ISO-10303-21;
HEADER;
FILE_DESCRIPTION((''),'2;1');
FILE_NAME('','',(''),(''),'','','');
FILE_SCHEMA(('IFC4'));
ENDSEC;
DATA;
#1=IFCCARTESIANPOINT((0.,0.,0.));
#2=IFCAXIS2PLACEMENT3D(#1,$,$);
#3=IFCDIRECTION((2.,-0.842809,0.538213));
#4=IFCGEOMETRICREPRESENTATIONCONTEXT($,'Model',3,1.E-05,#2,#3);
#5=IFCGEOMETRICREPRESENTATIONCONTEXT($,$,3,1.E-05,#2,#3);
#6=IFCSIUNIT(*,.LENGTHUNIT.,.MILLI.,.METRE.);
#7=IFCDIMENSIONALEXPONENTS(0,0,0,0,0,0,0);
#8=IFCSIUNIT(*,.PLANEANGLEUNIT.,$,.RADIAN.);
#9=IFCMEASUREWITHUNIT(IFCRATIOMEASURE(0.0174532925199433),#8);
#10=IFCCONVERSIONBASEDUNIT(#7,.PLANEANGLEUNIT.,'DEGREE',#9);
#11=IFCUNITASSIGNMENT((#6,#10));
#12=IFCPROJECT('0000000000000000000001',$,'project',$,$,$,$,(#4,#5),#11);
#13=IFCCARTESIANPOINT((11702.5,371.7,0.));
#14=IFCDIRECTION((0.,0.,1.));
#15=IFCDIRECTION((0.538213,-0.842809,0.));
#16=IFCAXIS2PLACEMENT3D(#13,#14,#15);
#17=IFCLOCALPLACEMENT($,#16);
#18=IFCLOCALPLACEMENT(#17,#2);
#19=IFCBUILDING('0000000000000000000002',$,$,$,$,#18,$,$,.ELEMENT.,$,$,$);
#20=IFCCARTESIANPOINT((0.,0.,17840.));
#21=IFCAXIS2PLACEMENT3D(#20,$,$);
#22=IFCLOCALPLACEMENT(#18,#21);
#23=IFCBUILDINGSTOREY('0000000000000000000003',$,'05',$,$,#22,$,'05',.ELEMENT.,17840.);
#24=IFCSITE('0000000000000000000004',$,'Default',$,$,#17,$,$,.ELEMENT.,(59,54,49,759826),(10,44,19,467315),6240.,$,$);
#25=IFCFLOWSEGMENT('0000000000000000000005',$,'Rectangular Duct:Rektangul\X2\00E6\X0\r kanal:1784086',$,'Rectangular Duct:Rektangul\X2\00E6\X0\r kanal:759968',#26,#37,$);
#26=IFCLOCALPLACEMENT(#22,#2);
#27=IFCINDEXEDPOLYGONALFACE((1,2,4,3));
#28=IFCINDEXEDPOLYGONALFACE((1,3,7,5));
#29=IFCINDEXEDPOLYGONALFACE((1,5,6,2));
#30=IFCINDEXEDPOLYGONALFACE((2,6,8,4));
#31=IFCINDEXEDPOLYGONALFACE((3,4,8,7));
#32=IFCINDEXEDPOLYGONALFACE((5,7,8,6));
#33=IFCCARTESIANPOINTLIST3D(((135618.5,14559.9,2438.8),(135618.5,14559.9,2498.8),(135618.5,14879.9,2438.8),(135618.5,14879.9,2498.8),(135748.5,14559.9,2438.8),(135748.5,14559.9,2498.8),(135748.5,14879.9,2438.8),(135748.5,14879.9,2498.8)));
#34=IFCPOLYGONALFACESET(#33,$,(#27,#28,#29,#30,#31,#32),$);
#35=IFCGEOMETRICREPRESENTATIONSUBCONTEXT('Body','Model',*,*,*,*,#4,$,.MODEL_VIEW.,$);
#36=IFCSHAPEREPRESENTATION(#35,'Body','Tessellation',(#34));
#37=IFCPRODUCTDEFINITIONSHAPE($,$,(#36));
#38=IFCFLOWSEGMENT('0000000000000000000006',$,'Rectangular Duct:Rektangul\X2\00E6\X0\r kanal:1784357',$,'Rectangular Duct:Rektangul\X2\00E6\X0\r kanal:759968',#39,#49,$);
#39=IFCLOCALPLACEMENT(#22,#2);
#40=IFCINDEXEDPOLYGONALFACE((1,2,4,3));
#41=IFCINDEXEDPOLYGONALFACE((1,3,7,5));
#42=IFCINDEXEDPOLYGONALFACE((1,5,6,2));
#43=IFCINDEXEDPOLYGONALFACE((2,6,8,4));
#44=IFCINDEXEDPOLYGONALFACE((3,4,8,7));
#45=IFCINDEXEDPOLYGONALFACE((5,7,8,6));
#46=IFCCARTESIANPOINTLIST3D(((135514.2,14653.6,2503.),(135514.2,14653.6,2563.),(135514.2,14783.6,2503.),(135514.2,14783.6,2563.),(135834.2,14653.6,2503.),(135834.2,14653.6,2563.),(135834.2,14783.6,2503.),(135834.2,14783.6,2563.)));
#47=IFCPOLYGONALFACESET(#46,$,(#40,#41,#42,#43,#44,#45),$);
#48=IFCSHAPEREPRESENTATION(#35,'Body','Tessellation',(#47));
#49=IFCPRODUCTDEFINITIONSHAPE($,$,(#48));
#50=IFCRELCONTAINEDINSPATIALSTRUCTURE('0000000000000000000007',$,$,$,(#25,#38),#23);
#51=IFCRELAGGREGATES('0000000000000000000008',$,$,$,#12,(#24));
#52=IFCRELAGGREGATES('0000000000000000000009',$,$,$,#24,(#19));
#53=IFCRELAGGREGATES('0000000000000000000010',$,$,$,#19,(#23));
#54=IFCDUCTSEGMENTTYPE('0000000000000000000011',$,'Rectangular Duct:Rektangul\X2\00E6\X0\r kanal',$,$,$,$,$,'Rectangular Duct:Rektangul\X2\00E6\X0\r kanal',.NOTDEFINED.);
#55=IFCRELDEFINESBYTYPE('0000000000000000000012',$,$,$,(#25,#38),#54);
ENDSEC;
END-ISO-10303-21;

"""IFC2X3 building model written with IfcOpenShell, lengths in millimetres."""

from ifc_helpers import new_model, entity, si_unit, converted_unit, direction, frame, frame_2d, origin, place, context, subcontext, project, spatial, rectangle, extrude, type_object, element, save


model = new_model("IFC2X3")

# Units and contexts
model_context = context("Model", 3, precision=1e-05, world=origin(), true_north=direction((2.0, -0.842809, 0.538213)))
context_of_model = context(None, 3, precision=1e-05, world=origin(), true_north=direction((2.0, -0.842809, 0.538213)))
body_context = subcontext(model_context, "Body", "Model", "MODEL_VIEW")
ifc_project = project(units=[si_unit("LENGTHUNIT", "METRE", prefix="MILLI"), converted_unit("PLANEANGLEUNIT", "DEGREE", entity("IfcRatioMeasure", 0.0174532925199433), si_unit("PLANEANGLEUNIT", "RADIAN"), dimensions=[0, 0, 0, 0, 0, 0, 0])], contexts=[model_context, context_of_model])

# Site, building, storey
site_placement = place(None, frame((11702.5, 371.7, 0.0), z_axis=(0.0, 0.0, 1.0), x_axis=(0.538213, -0.842809, 0.0)))
site = spatial("IfcSite", under=ifc_project, at=site_placement, Name="Default", CompositionType="ELEMENT", RefLatitude=(59, 54, 49, 759826), RefLongitude=(10, 44, 19, 467315), RefElevation=6240.0)
building_placement = place(site_placement, origin())
building = spatial("IfcBuilding", under=site, at=building_placement, CompositionType="ELEMENT")
storey_placement = place(building_placement, frame((0.0, 0.0, 17840.0)))
storey = spatial("IfcBuildingStorey", under=building, at=storey_placement, Name="05", LongName="05", CompositionType="ELEMENT", Elevation=17840.0)

# Flow segments
duct_segment_type_1 = type_object("IfcDuctSegmentType", Name="Rectangular Duct:Rektangulær kanal", ElementType="Rectangular Duct:Rektangulær kanal", PredefinedType="NOTDEFINED")
flow_segment_1_placement = place(storey_placement, origin())
element("IfcFlowSegment", 1, at=flow_segment_1_placement, inside=storey, type_object=duct_segment_type_1, Name="Rectangular Duct:Rektangulær kanal:1784086", ObjectType="Rectangular Duct:Rektangulær kanal:759968", context=body_context, shape_type="SweptSolid", body=[
    extrude(rectangle(XDim=320.0, YDim=130.0, at=frame_2d((0.0, 0.0), x_axis=(1.0, 0.0))), frame((135683.5, 14719.9, 2438.8), z_axis=(0.0, 0.0, 1.0), x_axis=(0.0, 1.0, 0.0)), (0.0, 0.0, 1.0), 60.0),
])
flow_segment_2_placement = place(storey_placement, origin())
element("IfcFlowSegment", 2, at=flow_segment_2_placement, inside=storey, type_object=duct_segment_type_1, Name="Rectangular Duct:Rektangulær kanal:1784357", ObjectType="Rectangular Duct:Rektangulær kanal:759968", context=body_context, shape_type="SweptSolid", body=[
    extrude(rectangle(XDim=320.0, YDim=130.0, at=frame_2d((0.0, 0.0), x_axis=(1.0, 0.0))), frame((135674.2, 14718.6, 2503.0)), (0.0, 0.0, 1.0), 60.0),
])

save(model, "model.ifc")
